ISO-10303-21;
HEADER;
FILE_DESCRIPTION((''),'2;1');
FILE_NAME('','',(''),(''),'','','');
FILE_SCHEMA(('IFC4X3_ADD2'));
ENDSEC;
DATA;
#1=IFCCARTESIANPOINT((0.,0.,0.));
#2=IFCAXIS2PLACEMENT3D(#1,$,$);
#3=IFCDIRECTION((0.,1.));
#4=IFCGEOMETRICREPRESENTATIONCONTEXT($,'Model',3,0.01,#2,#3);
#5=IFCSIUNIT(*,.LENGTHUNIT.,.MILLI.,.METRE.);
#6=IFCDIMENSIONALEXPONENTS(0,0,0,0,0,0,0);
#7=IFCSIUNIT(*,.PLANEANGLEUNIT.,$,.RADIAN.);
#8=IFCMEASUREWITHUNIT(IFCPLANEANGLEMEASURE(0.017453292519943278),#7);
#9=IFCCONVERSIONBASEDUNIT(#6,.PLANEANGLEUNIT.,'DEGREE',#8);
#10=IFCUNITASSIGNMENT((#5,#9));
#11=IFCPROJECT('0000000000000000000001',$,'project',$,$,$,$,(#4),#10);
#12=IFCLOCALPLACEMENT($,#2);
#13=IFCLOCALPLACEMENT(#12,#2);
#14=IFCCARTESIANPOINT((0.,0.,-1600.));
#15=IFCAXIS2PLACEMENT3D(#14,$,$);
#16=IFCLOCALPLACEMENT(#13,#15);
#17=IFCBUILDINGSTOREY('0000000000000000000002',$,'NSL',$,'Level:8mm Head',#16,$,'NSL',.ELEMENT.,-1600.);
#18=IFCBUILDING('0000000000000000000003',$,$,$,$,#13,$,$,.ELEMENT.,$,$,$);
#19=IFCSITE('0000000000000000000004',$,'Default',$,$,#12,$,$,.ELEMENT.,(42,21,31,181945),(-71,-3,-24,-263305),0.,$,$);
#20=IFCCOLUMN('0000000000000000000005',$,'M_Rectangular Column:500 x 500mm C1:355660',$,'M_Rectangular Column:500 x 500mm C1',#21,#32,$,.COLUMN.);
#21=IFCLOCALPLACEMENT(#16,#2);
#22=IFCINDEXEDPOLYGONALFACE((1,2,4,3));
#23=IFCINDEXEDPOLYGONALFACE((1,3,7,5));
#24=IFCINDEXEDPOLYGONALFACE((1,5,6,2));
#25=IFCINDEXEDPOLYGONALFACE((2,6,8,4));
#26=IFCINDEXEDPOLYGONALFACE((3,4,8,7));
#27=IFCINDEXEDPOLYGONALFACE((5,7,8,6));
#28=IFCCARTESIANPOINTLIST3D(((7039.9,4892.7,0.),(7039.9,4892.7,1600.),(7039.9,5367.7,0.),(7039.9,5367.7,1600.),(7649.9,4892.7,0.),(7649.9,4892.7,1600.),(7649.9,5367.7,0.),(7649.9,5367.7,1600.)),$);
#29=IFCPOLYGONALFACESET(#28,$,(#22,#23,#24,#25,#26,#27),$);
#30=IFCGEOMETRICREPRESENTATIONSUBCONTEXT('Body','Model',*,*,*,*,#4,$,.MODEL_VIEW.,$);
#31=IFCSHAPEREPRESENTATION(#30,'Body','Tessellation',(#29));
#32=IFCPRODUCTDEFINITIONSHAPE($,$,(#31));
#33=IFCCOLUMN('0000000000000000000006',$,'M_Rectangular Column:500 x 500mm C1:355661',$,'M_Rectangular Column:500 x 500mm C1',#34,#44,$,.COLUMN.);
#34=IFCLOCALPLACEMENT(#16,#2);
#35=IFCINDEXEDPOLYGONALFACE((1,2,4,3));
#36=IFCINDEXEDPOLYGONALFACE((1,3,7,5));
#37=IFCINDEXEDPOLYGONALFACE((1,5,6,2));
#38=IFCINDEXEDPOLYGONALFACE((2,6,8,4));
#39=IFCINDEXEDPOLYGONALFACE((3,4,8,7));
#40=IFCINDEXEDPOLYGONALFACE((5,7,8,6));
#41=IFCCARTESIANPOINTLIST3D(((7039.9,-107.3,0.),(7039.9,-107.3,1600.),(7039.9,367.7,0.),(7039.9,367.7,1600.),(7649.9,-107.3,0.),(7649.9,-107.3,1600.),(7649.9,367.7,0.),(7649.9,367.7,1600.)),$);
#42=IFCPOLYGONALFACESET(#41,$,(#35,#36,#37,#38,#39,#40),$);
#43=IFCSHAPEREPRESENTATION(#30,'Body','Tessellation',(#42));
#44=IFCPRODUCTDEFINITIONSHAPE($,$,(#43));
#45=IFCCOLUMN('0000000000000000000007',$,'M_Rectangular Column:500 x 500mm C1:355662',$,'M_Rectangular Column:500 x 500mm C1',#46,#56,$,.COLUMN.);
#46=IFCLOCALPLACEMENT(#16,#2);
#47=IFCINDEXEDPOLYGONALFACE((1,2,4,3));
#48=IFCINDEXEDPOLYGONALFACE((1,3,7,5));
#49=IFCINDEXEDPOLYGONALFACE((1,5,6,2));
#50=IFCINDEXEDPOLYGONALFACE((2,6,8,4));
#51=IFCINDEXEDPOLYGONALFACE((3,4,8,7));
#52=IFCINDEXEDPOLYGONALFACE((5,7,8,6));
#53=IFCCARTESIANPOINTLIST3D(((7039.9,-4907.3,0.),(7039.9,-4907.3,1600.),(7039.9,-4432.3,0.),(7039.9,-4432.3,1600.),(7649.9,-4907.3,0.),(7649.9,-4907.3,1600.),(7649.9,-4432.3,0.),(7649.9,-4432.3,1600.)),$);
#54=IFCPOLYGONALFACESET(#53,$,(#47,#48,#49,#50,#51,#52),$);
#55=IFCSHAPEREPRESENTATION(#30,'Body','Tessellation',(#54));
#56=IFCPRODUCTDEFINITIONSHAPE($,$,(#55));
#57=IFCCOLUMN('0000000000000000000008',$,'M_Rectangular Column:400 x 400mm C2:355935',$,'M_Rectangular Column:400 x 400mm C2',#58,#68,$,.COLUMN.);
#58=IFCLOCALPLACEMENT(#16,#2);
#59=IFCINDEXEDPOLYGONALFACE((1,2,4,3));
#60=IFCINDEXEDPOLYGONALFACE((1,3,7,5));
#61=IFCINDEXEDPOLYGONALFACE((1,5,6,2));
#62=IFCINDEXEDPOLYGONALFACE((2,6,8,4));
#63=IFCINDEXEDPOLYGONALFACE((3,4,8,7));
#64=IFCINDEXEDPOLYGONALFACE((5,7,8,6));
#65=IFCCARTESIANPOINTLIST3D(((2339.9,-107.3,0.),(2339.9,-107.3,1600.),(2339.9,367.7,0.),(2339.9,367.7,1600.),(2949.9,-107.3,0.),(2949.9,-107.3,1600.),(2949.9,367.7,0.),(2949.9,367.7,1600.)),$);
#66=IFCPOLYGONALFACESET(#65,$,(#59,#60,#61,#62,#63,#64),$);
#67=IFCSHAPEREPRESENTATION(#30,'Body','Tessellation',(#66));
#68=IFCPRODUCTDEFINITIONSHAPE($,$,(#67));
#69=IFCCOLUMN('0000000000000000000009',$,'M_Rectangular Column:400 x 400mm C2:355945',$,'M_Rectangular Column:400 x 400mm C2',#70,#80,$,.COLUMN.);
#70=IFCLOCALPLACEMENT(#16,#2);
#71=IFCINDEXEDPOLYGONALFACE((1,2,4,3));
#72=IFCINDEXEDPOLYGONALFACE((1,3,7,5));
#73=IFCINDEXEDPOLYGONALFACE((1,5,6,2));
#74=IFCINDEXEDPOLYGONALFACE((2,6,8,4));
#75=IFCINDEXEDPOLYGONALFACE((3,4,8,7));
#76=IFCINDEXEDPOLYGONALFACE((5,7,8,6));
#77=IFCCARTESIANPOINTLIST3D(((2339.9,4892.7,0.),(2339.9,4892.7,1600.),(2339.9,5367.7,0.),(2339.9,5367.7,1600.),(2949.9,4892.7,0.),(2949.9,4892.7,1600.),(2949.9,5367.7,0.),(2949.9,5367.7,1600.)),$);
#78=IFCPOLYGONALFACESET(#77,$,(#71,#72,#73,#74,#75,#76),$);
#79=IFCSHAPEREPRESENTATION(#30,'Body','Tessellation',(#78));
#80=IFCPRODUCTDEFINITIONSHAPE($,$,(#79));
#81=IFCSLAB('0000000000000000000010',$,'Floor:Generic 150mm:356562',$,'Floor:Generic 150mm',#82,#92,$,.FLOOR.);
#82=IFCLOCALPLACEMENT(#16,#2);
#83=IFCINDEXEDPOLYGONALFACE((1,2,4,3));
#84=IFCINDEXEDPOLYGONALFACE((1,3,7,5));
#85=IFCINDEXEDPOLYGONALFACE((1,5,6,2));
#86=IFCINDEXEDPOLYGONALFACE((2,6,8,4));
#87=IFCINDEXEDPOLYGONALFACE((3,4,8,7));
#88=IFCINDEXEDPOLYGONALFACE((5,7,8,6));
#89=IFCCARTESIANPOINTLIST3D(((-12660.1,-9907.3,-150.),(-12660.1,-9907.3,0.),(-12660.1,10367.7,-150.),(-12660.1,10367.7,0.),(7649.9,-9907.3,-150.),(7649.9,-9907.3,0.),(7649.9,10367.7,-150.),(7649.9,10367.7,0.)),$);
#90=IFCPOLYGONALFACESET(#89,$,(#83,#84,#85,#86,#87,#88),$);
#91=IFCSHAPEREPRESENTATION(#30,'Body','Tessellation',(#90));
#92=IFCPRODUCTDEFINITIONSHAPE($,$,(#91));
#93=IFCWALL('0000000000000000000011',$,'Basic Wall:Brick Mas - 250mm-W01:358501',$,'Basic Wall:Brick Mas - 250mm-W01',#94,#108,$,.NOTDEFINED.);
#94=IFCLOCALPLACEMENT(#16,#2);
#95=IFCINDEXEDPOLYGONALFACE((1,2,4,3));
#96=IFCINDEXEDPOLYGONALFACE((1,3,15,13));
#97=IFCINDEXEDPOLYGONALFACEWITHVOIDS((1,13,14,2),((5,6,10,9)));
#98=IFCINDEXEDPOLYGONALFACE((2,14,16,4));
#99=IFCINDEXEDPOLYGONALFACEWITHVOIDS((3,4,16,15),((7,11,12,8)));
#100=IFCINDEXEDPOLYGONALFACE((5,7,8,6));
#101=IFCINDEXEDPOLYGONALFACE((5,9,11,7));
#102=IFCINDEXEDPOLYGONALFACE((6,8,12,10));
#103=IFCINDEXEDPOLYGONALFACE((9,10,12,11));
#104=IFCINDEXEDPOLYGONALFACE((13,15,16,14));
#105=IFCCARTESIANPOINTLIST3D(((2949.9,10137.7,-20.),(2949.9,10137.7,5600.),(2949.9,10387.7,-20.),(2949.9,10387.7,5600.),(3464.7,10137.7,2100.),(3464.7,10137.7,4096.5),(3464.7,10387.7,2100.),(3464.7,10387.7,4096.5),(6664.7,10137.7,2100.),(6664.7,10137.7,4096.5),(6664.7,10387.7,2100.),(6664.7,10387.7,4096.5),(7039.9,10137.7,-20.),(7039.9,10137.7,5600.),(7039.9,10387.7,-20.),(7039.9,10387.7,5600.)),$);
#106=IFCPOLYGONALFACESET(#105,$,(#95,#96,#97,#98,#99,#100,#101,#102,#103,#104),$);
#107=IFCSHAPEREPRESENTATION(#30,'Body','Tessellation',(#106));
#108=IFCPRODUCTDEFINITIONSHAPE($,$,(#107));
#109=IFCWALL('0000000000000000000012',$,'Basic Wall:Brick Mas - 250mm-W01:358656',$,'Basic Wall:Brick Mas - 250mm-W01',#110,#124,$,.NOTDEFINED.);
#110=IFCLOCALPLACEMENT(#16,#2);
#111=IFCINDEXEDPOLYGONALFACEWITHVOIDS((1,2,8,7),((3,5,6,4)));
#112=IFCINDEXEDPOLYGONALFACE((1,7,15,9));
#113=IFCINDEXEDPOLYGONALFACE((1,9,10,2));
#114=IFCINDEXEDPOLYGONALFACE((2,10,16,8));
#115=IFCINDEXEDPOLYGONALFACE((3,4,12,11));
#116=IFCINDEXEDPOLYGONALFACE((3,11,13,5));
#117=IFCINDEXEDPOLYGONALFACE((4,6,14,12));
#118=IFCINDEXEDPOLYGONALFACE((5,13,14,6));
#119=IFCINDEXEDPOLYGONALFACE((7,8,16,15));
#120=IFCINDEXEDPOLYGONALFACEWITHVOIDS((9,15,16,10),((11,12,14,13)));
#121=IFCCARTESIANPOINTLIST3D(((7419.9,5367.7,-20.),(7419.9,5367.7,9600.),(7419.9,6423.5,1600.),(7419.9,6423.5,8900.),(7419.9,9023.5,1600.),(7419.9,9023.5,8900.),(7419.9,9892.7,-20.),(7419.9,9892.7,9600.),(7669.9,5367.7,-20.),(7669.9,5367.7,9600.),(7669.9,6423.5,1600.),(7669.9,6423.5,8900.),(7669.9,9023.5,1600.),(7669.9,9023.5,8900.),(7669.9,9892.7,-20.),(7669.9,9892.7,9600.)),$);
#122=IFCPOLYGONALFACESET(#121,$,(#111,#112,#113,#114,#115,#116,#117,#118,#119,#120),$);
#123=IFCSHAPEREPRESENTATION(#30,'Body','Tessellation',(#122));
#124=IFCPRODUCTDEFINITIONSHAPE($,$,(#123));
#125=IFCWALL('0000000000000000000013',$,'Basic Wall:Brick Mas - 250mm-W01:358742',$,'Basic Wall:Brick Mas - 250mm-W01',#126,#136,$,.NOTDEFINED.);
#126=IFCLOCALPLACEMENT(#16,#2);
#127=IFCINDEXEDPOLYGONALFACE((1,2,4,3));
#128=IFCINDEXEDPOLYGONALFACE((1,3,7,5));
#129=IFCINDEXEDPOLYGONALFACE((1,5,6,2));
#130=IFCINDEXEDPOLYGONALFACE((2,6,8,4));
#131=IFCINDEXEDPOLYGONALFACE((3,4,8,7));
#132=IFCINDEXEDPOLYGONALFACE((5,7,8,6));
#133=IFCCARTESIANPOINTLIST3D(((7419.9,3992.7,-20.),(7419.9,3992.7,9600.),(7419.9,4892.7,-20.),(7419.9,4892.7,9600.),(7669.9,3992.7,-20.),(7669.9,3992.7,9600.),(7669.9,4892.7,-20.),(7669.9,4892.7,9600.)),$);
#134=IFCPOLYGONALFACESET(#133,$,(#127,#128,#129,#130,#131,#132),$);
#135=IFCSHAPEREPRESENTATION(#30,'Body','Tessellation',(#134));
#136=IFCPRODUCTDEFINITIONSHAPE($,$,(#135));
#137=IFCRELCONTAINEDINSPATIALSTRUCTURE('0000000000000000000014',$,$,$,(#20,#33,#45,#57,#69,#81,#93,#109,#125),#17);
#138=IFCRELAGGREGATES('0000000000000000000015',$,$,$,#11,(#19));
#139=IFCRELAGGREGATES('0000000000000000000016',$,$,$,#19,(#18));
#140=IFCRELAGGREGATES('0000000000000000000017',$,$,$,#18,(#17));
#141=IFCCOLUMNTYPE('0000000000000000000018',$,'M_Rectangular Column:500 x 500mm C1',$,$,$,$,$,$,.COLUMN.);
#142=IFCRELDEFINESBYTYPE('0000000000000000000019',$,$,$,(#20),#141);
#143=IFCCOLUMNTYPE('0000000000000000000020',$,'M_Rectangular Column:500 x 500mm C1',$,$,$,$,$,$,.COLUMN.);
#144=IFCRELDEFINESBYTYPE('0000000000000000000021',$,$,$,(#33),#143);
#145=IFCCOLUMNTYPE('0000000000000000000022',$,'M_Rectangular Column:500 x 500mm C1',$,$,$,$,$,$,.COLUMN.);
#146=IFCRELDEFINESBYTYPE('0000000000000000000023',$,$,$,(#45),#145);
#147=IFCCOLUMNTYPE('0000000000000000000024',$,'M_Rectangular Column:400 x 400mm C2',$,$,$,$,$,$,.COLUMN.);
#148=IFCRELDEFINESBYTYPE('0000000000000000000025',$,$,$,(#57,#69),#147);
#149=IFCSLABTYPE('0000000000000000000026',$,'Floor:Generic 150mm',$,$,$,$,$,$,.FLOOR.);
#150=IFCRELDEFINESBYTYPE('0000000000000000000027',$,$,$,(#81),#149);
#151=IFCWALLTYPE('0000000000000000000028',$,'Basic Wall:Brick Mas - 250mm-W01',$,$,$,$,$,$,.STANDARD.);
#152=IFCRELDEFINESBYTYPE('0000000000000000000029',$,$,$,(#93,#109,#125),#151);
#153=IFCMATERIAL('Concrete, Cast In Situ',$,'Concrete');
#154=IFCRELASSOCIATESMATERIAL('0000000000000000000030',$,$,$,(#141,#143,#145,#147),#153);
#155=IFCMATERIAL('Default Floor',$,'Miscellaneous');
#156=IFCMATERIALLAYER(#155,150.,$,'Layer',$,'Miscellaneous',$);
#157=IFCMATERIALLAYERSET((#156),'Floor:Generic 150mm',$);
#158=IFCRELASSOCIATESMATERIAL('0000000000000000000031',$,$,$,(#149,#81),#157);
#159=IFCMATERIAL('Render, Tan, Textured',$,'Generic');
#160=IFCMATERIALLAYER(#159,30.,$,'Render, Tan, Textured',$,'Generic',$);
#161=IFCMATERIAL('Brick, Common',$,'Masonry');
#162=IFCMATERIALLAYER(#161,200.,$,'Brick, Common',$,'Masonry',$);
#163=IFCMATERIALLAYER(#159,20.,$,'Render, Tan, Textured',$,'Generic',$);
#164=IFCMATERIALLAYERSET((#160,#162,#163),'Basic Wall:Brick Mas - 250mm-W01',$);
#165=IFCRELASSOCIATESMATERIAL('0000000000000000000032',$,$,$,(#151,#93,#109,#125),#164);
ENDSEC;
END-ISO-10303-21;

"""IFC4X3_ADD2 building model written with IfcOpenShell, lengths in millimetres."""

from ifc_helpers import new_model, entity, si_unit, converted_unit, direction, frame, frame_2d, origin, origin_2d_with_axis, place, context, subcontext, project, spatial, rectangle, extrude, source, transform, mapped, material, layer, layer_set, layer_usage, material_profile, profile_set, type_object, type_shapes, element, save


model = new_model("IFC4X3_ADD2")

# Units and contexts
model_context = context("Model", 3, precision=0.01, world=origin(), true_north=direction((0.0, 1.0)))
body_context = subcontext(model_context, "Body", "Model", "MODEL_VIEW")
ifc_project = project(units=[si_unit("LENGTHUNIT", "METRE", prefix="MILLI"), converted_unit("PLANEANGLEUNIT", "DEGREE", entity("IfcPlaneAngleMeasure", 0.017453292519943278), si_unit("PLANEANGLEUNIT", "RADIAN"), dimensions=[0, 0, 0, 0, 0, 0, 0])], contexts=[model_context])

# Site, building, storey
site_placement = place(None, origin())
site = spatial("IfcSite", under=ifc_project, at=site_placement, Name="Default", CompositionType="ELEMENT", RefLatitude=(42, 21, 31, 181945), RefLongitude=(-71, -3, -24, -263305), RefElevation=0.0)
building_placement = place(site_placement, origin())
building = spatial("IfcBuilding", under=site, at=building_placement, CompositionType="ELEMENT")
storey_placement = place(building_placement, frame((0.0, 0.0, -1600.0)))
storey = spatial("IfcBuildingStorey", under=building, at=storey_placement, Name="NSL", ObjectType="Level:8mm Head", LongName="NSL", CompositionType="ELEMENT", Elevation=-1600.0)

# Columns
ifc_material_1 = material(Name="Concrete, Cast In Situ", Category="Concrete")
ifc_material_profile_1 = material_profile(ifc_material_1, rectangle(XDim=610.0, YDim=475.0, at=frame_2d((0.0, 0.0), x_axis=(1.0, 0.0))), Name="500 x 500mm C1")
ifc_profile_set_1 = profile_set([ifc_material_profile_1], Name="500 x 500mm C1")
column_type_1 = type_object("IfcColumnType", Name="M_Rectangular Column:500 x 500mm C1", PredefinedType="COLUMN", material=ifc_profile_set_1)
shared_shape_1 = source(origin(), body_context, "Body", "SweptSolid", [
    extrude(rectangle(XDim=610.0, YDim=475.0, at=frame_2d((0.0, 0.0), x_axis=(1.0, 0.0))), frame((7344.9, 5130.2, -1600.0), z_axis=(0.0, 0.0, 1.0), x_axis=(-1.0, 0.0, 0.0)), (0.0, 0.0, 1.0), 1600.0),
])
type_shapes(column_type_1, [shared_shape_1])
column_1_placement = place(storey_placement, frame((0.0, 0.0, 1600.0)))
element("IfcColumn", 1, at=column_1_placement, inside=storey, type_object=column_type_1, Name="M_Rectangular Column:500 x 500mm C1:355660", ObjectType="M_Rectangular Column:500 x 500mm C1", PredefinedType="COLUMN", context=body_context, shape_type="MappedRepresentation", body=[
    mapped(shared_shape_1, transform((0.0, 0.0, 0.0), scale=1.0)),
])
column_type_2 = type_object("IfcColumnType", Name="M_Rectangular Column:500 x 500mm C1", PredefinedType="COLUMN", material=ifc_profile_set_1)
shared_shape_2 = source(origin(), body_context, "Body", "SweptSolid", [
    extrude(rectangle(XDim=610.0, YDim=475.0, at=origin_2d_with_axis()), frame((7344.9, 130.2, -1600.0), z_axis=(0.0, 0.0, 1.0), x_axis=(-1.0, 0.0, 0.0)), (0.0, 0.0, 1.0), 1600.0),
])
type_shapes(column_type_2, [shared_shape_2])
column_2_placement = place(storey_placement, frame((0.0, 0.0, 1600.0)))
element("IfcColumn", 2, at=column_2_placement, inside=storey, type_object=column_type_2, Name="M_Rectangular Column:500 x 500mm C1:355661", ObjectType="M_Rectangular Column:500 x 500mm C1", PredefinedType="COLUMN", context=body_context, shape_type="MappedRepresentation", body=[
    mapped(shared_shape_2, transform((0.0, 0.0, 0.0), scale=1.0)),
])
column_type_3 = type_object("IfcColumnType", Name="M_Rectangular Column:500 x 500mm C1", PredefinedType="COLUMN", material=ifc_profile_set_1)
shared_shape_3 = source(origin(), body_context, "Body", "SweptSolid", [
    extrude(rectangle(XDim=610.0, YDim=475.0, at=origin_2d_with_axis()), frame((7344.9, -4669.8, -1600.0), z_axis=(0.0, 0.0, 1.0), x_axis=(-1.0, 0.0, 0.0)), (0.0, 0.0, 1.0), 1600.0),
])
type_shapes(column_type_3, [shared_shape_3])
column_3_placement = place(storey_placement, frame((0.0, 0.0, 1600.0)))
element("IfcColumn", 3, at=column_3_placement, inside=storey, type_object=column_type_3, Name="M_Rectangular Column:500 x 500mm C1:355662", ObjectType="M_Rectangular Column:500 x 500mm C1", PredefinedType="COLUMN", context=body_context, shape_type="MappedRepresentation", body=[
    mapped(shared_shape_3, transform((0.0, 0.0, 0.0), scale=1.0)),
])
ifc_material_profile_2 = material_profile(ifc_material_1, rectangle(XDim=610.0, YDim=475.0, at=origin_2d_with_axis()), Name="400 x 400mm C2")
ifc_profile_set_2 = profile_set([ifc_material_profile_2], Name="400 x 400mm C2")
column_type_4 = type_object("IfcColumnType", Name="M_Rectangular Column:400 x 400mm C2", PredefinedType="COLUMN", material=ifc_profile_set_2)
shared_shape_4 = source(origin(), body_context, "Body", "SweptSolid", [
    extrude(rectangle(XDim=610.0, YDim=475.0, at=origin_2d_with_axis()), frame((0.0, 0.0, -1600.0), z_axis=(0.0, 0.0, 1.0), x_axis=(-1.0, 0.0, 0.0)), (0.0, 0.0, 1.0), 1600.0),
])
type_shapes(column_type_4, [shared_shape_4])
for number, where, name in (
    (4, (2644.9, 130.2, 1600.0), "M_Rectangular Column:400 x 400mm C2:355935"),
    (5, (2644.9, 5130.2, 1600.0), "M_Rectangular Column:400 x 400mm C2:355945"),
):
    element("IfcColumn", number, at=place(storey_placement, frame(where)), inside=storey, type_object=column_type_4, Name=name, ObjectType="M_Rectangular Column:400 x 400mm C2", PredefinedType="COLUMN", context=body_context, shape_type="MappedRepresentation", body=[
        mapped(shared_shape_4, transform((0.0, 0.0, 0.0), scale=1.0)),
    ])

# Slab
ifc_material_2 = material(Name="Default Floor", Category="Miscellaneous")
ifc_layer_1 = layer(ifc_material_2, 150.0, Name="Layer", Category="Miscellaneous")
ifc_layer_set_1 = layer_set([ifc_layer_1], Name="Floor:Generic 150mm")
ifc_layer_usage_1 = layer_usage(ifc_layer_set_1, "AXIS3", "POSITIVE", 0.0)
slab_type = type_object("IfcSlabType", Name="Floor:Generic 150mm", PredefinedType="FLOOR", material=ifc_layer_set_1)
slab_placement = place(storey_placement, origin())
element("IfcSlab", 6, at=slab_placement, inside=storey, type_object=slab_type, material=ifc_layer_usage_1, Name="Floor:Generic 150mm:356562", ObjectType="Floor:Generic 150mm", PredefinedType="FLOOR", context=body_context, shape_type="SweptSolid", body=[
    extrude(rectangle(XDim=20275.0, YDim=20310.0, at=origin_2d_with_axis()), frame((-2505.1, 230.2, 0.0), z_axis=(0.0, 0.0, -1.0), x_axis=(0.0, 1.0, 0.0)), (0.0, 0.0, 1.0), 150.0),
])

# Walls, openings
ifc_material_3 = material(Name="Render, Tan, Textured", Category="Generic")
ifc_layer_2 = layer(ifc_material_3, 30.0, Name="Render, Tan, Textured", Category="Generic")
ifc_material_4 = material(Name="Brick, Common", Category="Masonry")
ifc_layer_3 = layer(ifc_material_4, 200.0, Name="Brick, Common", Category="Masonry")
ifc_layer_4 = layer(ifc_material_3, 20.0, Name="Render, Tan, Textured", Category="Generic")
ifc_layer_set_2 = layer_set([ifc_layer_2, ifc_layer_3, ifc_layer_4], Name="Basic Wall:Brick Mas - 250mm-W01")
wall_type = type_object("IfcWallType", Name="Basic Wall:Brick Mas - 250mm-W01", PredefinedType="STANDARD", material=ifc_layer_set_2)
wall_1_placement = place(storey_placement, frame((2949.9, 10262.7, -20.0)))
wall_1 = element("IfcWall", 7, at=wall_1_placement, inside=storey, type_object=wall_type, material=ifc_layer_set_2, Name="Basic Wall:Brick Mas - 250mm-W01:358501", ObjectType="Basic Wall:Brick Mas - 250mm-W01", PredefinedType="NOTDEFINED", context=body_context, shape_type="SweptSolid", body=[
    extrude(rectangle(XDim=4090.0, YDim=250.0, at=frame_2d((2045.0, 0.0), x_axis=(-1.0, 0.0))), origin(), (0.0, 0.0, 1.0), 5620.0),
])
opening_1_placement = place(wall_1_placement, origin())
element("IfcOpeningElement", 8, at=opening_1_placement, cuts=wall_1, PredefinedType="OPENING", context=body_context, shape_type="SweptSolid", body=[
    extrude(rectangle(XDim=1996.5, YDim=3200.0, at=frame_2d((0.0, 0.0), x_axis=(1.0, 0.0))), frame((2114.8, 125.0, 3118.2), z_axis=(0.0, -1.0, 0.0), x_axis=(0.0, 0.0, 1.0)), (0.0, 0.0, 1.0), 250.0),
])
wall_2_placement = place(storey_placement, frame((7544.9, 9892.7, -20.0), z_axis=(0.0, 0.0, 1.0), x_axis=(0.0, -1.0, 0.0)))
wall_2 = element("IfcWall", 9, at=wall_2_placement, inside=storey, type_object=wall_type, material=ifc_layer_set_2, Name="Basic Wall:Brick Mas - 250mm-W01:358656", ObjectType="Basic Wall:Brick Mas - 250mm-W01", PredefinedType="NOTDEFINED", context=body_context, shape_type="SweptSolid", body=[
    extrude(rectangle(XDim=4525.0, YDim=250.0, at=frame_2d((2262.5, 0.0), x_axis=(-1.0, 0.0))), origin(), (0.0, 0.0, 1.0), 9620.0),
])
opening_2_placement = place(wall_2_placement, origin())
element("IfcOpeningElement", 10, at=opening_2_placement, cuts=wall_2, PredefinedType="OPENING", context=body_context, shape_type="SweptSolid", body=[
    extrude(rectangle(XDim=7300.0, YDim=2600.0, at=frame_2d((0.0, 0.0), x_axis=(0.0, 1.0))), frame((2169.2, 125.0, 5270.0), z_axis=(0.0, -1.0, 0.0), x_axis=(1.0, 0.0, 0.0)), (0.0, 0.0, 1.0), 250.0),
])

# Wall
wall_3_placement = place(storey_placement, frame((7544.9, 4892.7, -20.0), z_axis=(0.0, 0.0, 1.0), x_axis=(0.0, -1.0, 0.0)))
element("IfcWall", 11, at=wall_3_placement, inside=storey, type_object=wall_type, material=ifc_layer_set_2, Name="Basic Wall:Brick Mas - 250mm-W01:358742", ObjectType="Basic Wall:Brick Mas - 250mm-W01", PredefinedType="NOTDEFINED", context=body_context, shape_type="SweptSolid", body=[
    extrude(rectangle(XDim=900.0, YDim=250.0, at=frame_2d((450.0, 0.0), x_axis=(-1.0, 0.0))), origin(), (0.0, 0.0, 1.0), 9620.0),
])

save(model, "model.ifc")
